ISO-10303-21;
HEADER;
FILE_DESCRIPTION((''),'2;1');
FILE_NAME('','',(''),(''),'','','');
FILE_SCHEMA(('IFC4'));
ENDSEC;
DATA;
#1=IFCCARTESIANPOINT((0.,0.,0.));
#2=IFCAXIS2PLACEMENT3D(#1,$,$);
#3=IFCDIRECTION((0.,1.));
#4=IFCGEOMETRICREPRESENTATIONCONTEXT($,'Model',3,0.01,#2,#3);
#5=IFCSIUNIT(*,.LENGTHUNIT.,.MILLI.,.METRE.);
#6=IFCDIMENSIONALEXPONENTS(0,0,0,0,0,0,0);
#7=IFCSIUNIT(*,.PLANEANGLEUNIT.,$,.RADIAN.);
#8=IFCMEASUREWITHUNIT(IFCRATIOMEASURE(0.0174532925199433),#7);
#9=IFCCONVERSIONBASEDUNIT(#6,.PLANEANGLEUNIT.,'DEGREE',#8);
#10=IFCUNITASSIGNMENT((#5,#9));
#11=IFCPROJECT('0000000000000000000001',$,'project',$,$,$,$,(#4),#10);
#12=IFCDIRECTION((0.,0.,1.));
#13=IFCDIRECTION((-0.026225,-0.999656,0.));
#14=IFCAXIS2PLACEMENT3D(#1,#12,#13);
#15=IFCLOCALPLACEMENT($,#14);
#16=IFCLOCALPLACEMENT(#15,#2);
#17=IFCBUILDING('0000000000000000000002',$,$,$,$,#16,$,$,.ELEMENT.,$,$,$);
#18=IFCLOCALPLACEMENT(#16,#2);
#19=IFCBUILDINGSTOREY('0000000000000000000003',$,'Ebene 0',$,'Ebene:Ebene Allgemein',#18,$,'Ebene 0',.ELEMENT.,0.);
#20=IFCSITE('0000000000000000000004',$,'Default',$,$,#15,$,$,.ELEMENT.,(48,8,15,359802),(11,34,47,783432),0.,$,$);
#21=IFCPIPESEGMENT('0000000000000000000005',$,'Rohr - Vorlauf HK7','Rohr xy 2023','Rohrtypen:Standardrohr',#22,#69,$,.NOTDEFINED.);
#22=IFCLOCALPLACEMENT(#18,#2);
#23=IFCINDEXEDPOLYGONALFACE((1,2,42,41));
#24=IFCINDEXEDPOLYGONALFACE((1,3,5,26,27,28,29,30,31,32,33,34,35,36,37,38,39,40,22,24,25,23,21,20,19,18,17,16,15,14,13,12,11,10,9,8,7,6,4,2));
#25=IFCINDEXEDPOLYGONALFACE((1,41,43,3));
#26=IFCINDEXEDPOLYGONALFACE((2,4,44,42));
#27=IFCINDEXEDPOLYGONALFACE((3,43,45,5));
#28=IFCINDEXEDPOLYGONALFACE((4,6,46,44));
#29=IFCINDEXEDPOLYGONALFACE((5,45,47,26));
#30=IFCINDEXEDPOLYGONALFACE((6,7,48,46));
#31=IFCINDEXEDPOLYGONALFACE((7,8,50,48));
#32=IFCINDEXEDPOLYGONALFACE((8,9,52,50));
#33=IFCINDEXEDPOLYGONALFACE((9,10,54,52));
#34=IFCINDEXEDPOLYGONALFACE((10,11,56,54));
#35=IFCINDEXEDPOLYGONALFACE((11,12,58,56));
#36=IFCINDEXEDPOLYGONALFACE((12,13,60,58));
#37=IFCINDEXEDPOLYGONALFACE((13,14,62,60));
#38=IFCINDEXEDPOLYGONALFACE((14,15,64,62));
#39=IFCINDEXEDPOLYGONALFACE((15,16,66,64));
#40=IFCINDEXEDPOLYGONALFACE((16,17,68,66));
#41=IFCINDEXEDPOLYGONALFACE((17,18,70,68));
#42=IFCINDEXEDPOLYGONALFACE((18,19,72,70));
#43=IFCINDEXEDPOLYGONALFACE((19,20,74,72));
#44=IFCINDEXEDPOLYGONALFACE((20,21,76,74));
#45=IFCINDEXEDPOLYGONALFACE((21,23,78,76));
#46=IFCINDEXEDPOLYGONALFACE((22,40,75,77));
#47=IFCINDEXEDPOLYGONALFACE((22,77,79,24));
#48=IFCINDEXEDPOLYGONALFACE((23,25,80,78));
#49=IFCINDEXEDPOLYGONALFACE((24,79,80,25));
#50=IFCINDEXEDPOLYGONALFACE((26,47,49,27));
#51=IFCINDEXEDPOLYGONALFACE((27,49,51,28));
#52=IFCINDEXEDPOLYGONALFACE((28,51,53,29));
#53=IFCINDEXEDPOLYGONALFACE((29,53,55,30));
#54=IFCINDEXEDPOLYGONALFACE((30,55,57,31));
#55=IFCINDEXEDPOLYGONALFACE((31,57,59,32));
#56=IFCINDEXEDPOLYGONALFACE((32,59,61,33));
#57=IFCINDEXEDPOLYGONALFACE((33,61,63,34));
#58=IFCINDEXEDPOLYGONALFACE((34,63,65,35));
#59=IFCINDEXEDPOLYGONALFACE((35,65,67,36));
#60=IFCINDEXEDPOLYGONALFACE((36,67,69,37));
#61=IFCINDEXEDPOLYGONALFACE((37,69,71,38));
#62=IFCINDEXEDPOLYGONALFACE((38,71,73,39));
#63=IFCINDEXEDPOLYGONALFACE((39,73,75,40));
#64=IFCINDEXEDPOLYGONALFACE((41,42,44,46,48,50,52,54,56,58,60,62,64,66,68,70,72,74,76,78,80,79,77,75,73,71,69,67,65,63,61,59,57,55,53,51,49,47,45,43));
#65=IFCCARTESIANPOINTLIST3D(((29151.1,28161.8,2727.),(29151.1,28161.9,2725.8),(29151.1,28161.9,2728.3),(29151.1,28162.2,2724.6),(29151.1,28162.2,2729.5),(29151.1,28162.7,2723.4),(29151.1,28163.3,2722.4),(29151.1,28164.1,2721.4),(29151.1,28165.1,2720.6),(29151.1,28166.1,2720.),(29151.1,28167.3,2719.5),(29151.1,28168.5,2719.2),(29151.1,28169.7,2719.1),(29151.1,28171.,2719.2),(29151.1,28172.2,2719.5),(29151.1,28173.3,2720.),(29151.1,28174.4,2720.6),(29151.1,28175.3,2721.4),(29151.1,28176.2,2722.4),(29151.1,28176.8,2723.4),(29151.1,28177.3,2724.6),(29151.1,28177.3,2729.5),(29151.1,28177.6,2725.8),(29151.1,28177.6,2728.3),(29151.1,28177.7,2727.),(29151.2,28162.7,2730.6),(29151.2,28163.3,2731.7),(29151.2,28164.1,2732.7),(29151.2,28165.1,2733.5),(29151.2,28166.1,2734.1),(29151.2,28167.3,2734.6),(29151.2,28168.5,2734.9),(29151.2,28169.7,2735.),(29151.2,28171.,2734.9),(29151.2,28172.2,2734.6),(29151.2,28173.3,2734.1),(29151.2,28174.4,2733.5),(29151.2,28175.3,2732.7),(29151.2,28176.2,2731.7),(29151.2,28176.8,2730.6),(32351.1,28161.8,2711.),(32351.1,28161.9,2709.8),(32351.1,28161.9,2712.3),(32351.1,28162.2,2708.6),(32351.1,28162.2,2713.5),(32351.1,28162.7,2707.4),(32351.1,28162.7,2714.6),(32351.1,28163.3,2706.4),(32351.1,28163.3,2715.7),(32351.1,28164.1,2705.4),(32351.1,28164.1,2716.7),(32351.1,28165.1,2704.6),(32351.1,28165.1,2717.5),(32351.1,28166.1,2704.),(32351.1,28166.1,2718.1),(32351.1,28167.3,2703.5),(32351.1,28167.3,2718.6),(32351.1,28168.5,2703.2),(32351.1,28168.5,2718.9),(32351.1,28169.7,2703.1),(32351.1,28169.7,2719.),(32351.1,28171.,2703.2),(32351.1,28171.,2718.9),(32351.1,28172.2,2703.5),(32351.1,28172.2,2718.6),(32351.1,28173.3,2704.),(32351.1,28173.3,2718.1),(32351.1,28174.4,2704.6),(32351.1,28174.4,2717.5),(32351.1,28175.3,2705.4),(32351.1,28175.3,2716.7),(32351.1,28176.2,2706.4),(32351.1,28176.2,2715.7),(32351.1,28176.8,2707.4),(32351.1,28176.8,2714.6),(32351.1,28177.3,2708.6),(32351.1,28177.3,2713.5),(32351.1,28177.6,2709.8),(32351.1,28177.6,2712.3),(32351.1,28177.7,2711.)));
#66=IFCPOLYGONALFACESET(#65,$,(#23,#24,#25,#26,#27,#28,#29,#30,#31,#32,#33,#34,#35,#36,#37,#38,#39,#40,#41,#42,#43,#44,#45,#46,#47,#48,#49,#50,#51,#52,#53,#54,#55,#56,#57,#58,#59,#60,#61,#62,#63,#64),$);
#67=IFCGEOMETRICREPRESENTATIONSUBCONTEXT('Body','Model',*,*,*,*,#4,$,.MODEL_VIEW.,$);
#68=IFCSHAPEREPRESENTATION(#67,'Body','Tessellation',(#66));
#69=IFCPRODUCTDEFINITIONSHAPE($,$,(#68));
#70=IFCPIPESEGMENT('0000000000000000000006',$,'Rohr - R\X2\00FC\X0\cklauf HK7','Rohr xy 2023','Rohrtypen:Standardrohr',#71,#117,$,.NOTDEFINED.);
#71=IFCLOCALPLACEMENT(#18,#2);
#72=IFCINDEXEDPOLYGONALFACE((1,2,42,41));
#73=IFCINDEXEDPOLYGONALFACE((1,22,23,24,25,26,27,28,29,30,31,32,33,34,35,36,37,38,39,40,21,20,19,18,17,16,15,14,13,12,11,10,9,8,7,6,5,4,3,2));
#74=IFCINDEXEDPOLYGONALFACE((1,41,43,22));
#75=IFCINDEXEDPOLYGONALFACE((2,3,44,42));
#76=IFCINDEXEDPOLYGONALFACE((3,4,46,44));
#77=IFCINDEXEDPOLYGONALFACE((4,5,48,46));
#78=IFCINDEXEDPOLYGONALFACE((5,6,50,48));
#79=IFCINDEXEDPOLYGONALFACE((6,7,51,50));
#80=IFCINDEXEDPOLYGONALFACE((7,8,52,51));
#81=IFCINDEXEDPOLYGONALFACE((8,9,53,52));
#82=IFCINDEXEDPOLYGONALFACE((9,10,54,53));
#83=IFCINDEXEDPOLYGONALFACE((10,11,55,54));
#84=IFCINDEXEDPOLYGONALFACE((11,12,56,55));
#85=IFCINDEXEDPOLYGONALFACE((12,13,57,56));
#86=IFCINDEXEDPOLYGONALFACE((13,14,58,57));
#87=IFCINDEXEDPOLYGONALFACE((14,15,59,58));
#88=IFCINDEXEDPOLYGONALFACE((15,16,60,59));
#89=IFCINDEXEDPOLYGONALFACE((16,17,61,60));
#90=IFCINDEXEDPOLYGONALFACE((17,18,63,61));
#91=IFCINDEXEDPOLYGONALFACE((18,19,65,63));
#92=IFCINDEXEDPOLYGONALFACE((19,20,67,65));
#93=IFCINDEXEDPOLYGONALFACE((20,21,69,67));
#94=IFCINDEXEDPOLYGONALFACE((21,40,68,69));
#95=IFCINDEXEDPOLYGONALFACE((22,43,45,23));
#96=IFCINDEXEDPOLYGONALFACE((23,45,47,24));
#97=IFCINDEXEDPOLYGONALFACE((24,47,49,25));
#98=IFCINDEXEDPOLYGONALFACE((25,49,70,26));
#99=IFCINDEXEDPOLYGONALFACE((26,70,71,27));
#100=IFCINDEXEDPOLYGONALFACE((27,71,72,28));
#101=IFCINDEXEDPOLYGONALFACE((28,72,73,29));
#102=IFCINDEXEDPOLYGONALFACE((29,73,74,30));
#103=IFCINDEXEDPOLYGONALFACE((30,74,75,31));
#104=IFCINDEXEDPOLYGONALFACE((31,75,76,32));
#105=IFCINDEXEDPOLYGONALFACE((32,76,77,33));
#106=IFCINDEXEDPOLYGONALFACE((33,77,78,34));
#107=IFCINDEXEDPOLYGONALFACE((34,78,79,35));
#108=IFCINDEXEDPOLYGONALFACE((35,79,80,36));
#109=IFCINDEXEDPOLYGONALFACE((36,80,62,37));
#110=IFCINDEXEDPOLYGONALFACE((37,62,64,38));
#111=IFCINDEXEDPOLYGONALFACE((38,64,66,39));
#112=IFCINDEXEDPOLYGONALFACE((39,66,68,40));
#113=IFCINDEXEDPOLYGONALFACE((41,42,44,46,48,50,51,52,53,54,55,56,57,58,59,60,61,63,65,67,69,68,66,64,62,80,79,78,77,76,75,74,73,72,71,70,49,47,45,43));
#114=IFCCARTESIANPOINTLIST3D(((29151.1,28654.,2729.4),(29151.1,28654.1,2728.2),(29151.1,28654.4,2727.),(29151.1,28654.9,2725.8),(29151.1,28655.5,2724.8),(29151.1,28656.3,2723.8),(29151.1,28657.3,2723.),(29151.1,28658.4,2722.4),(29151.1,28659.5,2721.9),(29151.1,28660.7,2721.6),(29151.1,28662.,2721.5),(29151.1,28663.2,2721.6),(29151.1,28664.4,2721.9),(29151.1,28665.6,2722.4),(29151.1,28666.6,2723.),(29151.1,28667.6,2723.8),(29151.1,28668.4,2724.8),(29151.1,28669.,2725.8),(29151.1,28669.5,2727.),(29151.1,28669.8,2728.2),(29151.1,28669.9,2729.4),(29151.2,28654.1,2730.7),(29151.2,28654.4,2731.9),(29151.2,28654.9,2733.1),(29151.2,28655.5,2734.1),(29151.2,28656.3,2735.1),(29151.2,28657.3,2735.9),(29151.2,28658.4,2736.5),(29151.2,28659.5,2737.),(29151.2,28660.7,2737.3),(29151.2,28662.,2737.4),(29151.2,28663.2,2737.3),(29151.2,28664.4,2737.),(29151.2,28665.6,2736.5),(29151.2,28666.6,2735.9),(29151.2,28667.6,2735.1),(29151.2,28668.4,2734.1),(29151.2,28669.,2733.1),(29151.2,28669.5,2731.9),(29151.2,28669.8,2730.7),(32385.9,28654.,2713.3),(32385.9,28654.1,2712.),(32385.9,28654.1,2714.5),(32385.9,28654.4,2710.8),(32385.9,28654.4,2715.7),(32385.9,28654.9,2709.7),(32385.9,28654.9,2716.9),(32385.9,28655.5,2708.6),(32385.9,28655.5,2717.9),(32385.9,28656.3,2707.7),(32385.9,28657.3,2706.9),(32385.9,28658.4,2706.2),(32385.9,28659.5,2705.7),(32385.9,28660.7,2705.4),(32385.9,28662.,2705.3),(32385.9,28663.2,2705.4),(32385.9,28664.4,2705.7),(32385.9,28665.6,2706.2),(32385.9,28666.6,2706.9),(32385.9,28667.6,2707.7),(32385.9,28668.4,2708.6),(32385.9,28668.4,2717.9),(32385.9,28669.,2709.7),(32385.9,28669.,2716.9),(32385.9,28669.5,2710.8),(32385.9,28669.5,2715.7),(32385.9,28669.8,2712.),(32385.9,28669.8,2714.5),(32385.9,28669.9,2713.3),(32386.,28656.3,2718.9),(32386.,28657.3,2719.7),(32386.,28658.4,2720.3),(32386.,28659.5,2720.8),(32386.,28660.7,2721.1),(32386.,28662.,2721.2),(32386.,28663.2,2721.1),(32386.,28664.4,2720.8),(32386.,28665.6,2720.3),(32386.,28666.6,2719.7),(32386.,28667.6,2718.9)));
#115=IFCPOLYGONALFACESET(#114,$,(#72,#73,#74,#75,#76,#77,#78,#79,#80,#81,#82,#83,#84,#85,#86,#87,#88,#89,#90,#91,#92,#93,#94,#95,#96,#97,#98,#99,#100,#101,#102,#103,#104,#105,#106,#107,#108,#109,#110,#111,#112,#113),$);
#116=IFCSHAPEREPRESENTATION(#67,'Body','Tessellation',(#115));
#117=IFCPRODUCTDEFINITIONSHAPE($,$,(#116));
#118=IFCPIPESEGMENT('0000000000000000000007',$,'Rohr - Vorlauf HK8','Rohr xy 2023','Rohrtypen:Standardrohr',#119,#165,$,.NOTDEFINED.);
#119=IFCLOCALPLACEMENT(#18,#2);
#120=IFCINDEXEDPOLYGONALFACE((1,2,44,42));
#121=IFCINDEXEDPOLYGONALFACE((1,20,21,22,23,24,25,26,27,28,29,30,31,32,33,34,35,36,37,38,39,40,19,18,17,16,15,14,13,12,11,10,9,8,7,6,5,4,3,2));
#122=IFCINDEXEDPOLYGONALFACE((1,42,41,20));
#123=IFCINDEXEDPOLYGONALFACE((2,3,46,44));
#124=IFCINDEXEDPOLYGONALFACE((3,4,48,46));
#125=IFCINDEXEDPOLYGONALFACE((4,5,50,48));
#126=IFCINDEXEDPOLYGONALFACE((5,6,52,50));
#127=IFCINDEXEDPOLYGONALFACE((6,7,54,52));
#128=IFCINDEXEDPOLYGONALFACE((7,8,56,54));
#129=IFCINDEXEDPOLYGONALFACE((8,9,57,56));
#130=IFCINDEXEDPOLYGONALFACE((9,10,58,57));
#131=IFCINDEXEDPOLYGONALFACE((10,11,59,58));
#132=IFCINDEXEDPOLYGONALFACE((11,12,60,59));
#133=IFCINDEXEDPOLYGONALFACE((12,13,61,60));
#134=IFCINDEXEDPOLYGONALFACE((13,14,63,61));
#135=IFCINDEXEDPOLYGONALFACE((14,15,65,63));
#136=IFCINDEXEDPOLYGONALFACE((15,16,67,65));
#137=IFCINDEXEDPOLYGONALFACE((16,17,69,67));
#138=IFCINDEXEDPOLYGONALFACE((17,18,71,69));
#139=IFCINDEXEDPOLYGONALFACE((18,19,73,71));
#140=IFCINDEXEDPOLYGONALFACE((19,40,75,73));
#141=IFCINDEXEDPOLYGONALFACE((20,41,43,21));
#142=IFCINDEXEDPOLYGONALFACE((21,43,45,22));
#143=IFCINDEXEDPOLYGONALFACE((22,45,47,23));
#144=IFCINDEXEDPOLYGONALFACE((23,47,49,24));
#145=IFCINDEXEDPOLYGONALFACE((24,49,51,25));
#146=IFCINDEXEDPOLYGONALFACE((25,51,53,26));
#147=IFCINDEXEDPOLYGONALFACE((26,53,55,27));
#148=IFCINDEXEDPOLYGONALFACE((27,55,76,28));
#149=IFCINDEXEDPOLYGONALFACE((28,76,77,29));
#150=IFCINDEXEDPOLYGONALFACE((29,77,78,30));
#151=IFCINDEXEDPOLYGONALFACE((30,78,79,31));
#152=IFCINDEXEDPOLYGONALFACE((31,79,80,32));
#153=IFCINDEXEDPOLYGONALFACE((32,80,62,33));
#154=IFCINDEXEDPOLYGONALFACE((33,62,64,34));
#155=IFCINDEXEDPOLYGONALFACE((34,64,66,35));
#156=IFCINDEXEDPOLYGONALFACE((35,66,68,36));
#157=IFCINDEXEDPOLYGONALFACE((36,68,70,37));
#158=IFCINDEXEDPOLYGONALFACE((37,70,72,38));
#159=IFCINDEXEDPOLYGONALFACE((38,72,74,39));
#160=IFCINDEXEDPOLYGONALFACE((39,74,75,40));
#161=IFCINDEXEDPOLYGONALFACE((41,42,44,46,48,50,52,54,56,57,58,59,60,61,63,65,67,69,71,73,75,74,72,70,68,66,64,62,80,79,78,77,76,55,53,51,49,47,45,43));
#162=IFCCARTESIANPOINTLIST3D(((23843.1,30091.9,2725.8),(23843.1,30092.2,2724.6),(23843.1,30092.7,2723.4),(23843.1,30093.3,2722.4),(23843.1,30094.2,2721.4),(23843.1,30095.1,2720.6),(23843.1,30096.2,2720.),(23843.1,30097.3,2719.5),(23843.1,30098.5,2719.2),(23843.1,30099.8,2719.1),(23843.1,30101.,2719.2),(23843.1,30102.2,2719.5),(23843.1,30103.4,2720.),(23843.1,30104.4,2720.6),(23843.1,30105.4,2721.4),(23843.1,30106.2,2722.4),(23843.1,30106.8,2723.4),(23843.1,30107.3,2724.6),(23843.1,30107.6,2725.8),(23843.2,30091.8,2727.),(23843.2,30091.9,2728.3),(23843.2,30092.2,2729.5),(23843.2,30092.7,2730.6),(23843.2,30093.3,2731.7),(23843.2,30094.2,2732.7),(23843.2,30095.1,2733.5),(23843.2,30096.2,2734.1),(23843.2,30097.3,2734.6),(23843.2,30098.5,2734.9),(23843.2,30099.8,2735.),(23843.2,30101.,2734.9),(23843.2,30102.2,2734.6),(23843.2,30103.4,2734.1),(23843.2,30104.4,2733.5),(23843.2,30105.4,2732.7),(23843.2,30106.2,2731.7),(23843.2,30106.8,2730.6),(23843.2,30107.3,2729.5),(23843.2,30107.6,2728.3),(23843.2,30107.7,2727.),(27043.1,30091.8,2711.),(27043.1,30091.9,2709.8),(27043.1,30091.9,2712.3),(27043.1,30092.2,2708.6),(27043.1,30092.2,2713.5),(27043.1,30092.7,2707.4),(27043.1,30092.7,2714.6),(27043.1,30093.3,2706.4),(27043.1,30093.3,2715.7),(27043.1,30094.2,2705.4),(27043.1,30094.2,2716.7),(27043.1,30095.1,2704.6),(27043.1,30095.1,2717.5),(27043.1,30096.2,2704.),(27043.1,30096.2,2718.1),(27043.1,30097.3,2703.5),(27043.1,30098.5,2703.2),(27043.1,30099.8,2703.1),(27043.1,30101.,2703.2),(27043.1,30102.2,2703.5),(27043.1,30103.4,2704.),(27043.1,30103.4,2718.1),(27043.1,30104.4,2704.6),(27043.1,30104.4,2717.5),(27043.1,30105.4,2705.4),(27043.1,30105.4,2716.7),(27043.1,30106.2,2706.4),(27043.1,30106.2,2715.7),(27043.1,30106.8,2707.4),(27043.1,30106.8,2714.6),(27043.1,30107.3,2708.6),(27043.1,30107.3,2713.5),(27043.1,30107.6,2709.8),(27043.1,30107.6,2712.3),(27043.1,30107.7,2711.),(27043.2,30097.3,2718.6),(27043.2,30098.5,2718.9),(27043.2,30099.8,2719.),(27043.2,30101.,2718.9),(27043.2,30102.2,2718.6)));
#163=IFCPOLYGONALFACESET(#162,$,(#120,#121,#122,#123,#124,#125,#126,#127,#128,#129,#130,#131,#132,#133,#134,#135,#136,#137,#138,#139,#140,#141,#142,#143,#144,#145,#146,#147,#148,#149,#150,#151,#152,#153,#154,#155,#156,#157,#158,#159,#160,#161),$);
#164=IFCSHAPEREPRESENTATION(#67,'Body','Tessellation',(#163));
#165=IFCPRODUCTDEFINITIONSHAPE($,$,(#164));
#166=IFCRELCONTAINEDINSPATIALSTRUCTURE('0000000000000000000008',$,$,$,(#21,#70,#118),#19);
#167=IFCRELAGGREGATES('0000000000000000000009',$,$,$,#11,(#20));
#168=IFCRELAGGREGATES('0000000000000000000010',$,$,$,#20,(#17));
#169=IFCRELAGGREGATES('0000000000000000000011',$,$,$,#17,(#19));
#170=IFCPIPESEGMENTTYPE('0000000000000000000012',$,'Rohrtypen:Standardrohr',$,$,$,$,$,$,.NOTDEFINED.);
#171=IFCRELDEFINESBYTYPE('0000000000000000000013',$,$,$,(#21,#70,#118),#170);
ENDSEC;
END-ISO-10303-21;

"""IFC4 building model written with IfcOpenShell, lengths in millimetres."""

from ifc_helpers import new_model, entity, si_unit, converted_unit, direction, frame, origin, place, context, subcontext, project, spatial, indexed_curve, outline, extrude, type_object, element, save


model = new_model("IFC4")

# Units and contexts
model_context = context("Model", 3, precision=0.01, world=origin(), true_north=direction((0.0, 1.0)))
body_context = subcontext(model_context, "Body", "Model", "MODEL_VIEW")
ifc_project = project(units=[si_unit("LENGTHUNIT", "METRE", prefix="MILLI"), converted_unit("PLANEANGLEUNIT", "DEGREE", entity("IfcRatioMeasure", 0.0174532925199433), si_unit("PLANEANGLEUNIT", "RADIAN"), dimensions=[0, 0, 0, 0, 0, 0, 0])], contexts=[model_context])

# Site, building, storey
site_placement = place(None, frame((0.0, 0.0, 0.0), z_axis=(0.0, 0.0, 1.0), x_axis=(-0.026225, -0.999656, 0.0)))
site = spatial("IfcSite", under=ifc_project, at=site_placement, Name="Default", CompositionType="ELEMENT", RefLatitude=(48, 8, 15, 359802), RefLongitude=(11, 34, 47, 783432), RefElevation=0.0)
building_placement = place(site_placement, origin())
building = spatial("IfcBuilding", under=site, at=building_placement, CompositionType="ELEMENT")
storey_placement = place(building_placement, origin())
storey = spatial("IfcBuildingStorey", under=building, at=storey_placement, Name="Ebene 0", ObjectType="Ebene:Ebene Allgemein", LongName="Ebene 0", CompositionType="ELEMENT", Elevation=0.0)

# Pipe segments
pipe_segment_type = type_object("IfcPipeSegmentType", Name="Rohrtypen:Standardrohr", PredefinedType="NOTDEFINED")
pipe_segment_1_placement = place(storey_placement, origin())
element("IfcPipeSegment", 1, at=pipe_segment_1_placement, inside=storey, type_object=pipe_segment_type, Name="Rohr - Vorlauf HK7", Description="Rohr xy 2023", ObjectType="Rohrtypen:Standardrohr", PredefinedType="NOTDEFINED", context=body_context, shape_type="SweptSolid", body=[
    extrude(outline(indexed_curve([(7.9, 0.0), (7.8, 1.2), (7.6, 2.5), (7.1, 3.6), (6.4, 4.7), (5.6, 5.6), (4.7, 6.4), (3.6, 7.1), (2.5, 7.6), (1.2, 7.8), (0.0, 7.9), (-1.2, 7.8), (-2.5, 7.6), (-3.6, 7.1), (-4.7, 6.4), (-5.6, 5.6), (-6.4, 4.7), (-7.1, 3.6), (-7.6, 2.5), (-7.8, 1.2), (-7.9, 0.0), (-7.8, -1.2), (-7.6, -2.5), (-7.1, -3.6), (-6.4, -4.7), (-5.6, -5.6), (-4.7, -6.4), (-3.6, -7.1), (-2.5, -7.6), (-1.2, -7.8), (0.0, -7.9), (1.2, -7.8), (2.5, -7.6), (3.6, -7.1), (4.7, -6.4), (5.6, -5.6), (6.4, -4.7), (7.1, -3.6), (7.6, -2.5), (7.8, -1.2), (7.9, 0.0)], self_intersect=False)), frame((32351.1, 28169.7, 2711.0), z_axis=(-0.999988, 0.0, 0.005), x_axis=(0.0, 1.0, 0.0)), (0.0, 0.0, 1.0), 3200.0),
])
pipe_segment_2_placement = place(storey_placement, origin())
element("IfcPipeSegment", 2, at=pipe_segment_2_placement, inside=storey, type_object=pipe_segment_type, Name="Rohr - Rücklauf HK7", Description="Rohr xy 2023", ObjectType="Rohrtypen:Standardrohr", PredefinedType="NOTDEFINED", context=body_context, shape_type="SweptSolid", body=[
    extrude(outline(indexed_curve([(7.9, 0.0), (7.8, 1.2), (7.6, 2.5), (7.1, 3.6), (6.4, 4.7), (5.6, 5.6), (4.7, 6.4), (3.6, 7.1), (2.5, 7.6), (1.2, 7.8), (0.0, 7.9), (-1.2, 7.8), (-2.5, 7.6), (-3.6, 7.1), (-4.7, 6.4), (-5.6, 5.6), (-6.4, 4.7), (-7.1, 3.6), (-7.6, 2.5), (-7.8, 1.2), (-7.9, 0.0), (-7.8, -1.2), (-7.6, -2.5), (-7.1, -3.6), (-6.4, -4.7), (-5.6, -5.6), (-4.7, -6.4), (-3.6, -7.1), (-2.5, -7.6), (-1.2, -7.8), (0.0, -7.9), (1.2, -7.8), (2.5, -7.6), (3.6, -7.1), (4.7, -6.4), (5.6, -5.6), (6.4, -4.7), (7.1, -3.6), (7.6, -2.5), (7.8, -1.2), (7.9, 0.0)], self_intersect=False)), frame((32385.9, 28662.0, 2713.3), z_axis=(-0.999988, 0.0, 0.005), x_axis=(0.0, 1.0, 0.0)), (0.0, 0.0, 1.0), 3234.8),
])
pipe_segment_3_placement = place(storey_placement, origin())
element("IfcPipeSegment", 3, at=pipe_segment_3_placement, inside=storey, type_object=pipe_segment_type, Name="Rohr - Vorlauf HK8", Description="Rohr xy 2023", ObjectType="Rohrtypen:Standardrohr", PredefinedType="NOTDEFINED", context=body_context, shape_type="SweptSolid", body=[
    extrude(outline(indexed_curve([(7.9, 0.0), (7.8, 1.2), (7.6, 2.5), (7.1, 3.6), (6.4, 4.7), (5.6, 5.6), (4.7, 6.4), (3.6, 7.1), (2.5, 7.6), (1.2, 7.8), (0.0, 7.9), (-1.2, 7.8), (-2.5, 7.6), (-3.6, 7.1), (-4.7, 6.4), (-5.6, 5.6), (-6.4, 4.7), (-7.1, 3.6), (-7.6, 2.5), (-7.8, 1.2), (-7.9, 0.0), (-7.8, -1.2), (-7.6, -2.5), (-7.1, -3.6), (-6.4, -4.7), (-5.6, -5.6), (-4.7, -6.4), (-3.6, -7.1), (-2.5, -7.6), (-1.2, -7.8), (0.0, -7.9), (1.2, -7.8), (2.5, -7.6), (3.6, -7.1), (4.7, -6.4), (5.6, -5.6), (6.4, -4.7), (7.1, -3.6), (7.6, -2.5), (7.8, -1.2), (7.9, 0.0)], self_intersect=False)), frame((27043.1, 30099.8, 2711.0), z_axis=(-0.999988, 0.0, 0.005), x_axis=(0.0, 1.0, 0.0)), (0.0, 0.0, 1.0), 3200.0),
])

save(model, "model.ifc")
